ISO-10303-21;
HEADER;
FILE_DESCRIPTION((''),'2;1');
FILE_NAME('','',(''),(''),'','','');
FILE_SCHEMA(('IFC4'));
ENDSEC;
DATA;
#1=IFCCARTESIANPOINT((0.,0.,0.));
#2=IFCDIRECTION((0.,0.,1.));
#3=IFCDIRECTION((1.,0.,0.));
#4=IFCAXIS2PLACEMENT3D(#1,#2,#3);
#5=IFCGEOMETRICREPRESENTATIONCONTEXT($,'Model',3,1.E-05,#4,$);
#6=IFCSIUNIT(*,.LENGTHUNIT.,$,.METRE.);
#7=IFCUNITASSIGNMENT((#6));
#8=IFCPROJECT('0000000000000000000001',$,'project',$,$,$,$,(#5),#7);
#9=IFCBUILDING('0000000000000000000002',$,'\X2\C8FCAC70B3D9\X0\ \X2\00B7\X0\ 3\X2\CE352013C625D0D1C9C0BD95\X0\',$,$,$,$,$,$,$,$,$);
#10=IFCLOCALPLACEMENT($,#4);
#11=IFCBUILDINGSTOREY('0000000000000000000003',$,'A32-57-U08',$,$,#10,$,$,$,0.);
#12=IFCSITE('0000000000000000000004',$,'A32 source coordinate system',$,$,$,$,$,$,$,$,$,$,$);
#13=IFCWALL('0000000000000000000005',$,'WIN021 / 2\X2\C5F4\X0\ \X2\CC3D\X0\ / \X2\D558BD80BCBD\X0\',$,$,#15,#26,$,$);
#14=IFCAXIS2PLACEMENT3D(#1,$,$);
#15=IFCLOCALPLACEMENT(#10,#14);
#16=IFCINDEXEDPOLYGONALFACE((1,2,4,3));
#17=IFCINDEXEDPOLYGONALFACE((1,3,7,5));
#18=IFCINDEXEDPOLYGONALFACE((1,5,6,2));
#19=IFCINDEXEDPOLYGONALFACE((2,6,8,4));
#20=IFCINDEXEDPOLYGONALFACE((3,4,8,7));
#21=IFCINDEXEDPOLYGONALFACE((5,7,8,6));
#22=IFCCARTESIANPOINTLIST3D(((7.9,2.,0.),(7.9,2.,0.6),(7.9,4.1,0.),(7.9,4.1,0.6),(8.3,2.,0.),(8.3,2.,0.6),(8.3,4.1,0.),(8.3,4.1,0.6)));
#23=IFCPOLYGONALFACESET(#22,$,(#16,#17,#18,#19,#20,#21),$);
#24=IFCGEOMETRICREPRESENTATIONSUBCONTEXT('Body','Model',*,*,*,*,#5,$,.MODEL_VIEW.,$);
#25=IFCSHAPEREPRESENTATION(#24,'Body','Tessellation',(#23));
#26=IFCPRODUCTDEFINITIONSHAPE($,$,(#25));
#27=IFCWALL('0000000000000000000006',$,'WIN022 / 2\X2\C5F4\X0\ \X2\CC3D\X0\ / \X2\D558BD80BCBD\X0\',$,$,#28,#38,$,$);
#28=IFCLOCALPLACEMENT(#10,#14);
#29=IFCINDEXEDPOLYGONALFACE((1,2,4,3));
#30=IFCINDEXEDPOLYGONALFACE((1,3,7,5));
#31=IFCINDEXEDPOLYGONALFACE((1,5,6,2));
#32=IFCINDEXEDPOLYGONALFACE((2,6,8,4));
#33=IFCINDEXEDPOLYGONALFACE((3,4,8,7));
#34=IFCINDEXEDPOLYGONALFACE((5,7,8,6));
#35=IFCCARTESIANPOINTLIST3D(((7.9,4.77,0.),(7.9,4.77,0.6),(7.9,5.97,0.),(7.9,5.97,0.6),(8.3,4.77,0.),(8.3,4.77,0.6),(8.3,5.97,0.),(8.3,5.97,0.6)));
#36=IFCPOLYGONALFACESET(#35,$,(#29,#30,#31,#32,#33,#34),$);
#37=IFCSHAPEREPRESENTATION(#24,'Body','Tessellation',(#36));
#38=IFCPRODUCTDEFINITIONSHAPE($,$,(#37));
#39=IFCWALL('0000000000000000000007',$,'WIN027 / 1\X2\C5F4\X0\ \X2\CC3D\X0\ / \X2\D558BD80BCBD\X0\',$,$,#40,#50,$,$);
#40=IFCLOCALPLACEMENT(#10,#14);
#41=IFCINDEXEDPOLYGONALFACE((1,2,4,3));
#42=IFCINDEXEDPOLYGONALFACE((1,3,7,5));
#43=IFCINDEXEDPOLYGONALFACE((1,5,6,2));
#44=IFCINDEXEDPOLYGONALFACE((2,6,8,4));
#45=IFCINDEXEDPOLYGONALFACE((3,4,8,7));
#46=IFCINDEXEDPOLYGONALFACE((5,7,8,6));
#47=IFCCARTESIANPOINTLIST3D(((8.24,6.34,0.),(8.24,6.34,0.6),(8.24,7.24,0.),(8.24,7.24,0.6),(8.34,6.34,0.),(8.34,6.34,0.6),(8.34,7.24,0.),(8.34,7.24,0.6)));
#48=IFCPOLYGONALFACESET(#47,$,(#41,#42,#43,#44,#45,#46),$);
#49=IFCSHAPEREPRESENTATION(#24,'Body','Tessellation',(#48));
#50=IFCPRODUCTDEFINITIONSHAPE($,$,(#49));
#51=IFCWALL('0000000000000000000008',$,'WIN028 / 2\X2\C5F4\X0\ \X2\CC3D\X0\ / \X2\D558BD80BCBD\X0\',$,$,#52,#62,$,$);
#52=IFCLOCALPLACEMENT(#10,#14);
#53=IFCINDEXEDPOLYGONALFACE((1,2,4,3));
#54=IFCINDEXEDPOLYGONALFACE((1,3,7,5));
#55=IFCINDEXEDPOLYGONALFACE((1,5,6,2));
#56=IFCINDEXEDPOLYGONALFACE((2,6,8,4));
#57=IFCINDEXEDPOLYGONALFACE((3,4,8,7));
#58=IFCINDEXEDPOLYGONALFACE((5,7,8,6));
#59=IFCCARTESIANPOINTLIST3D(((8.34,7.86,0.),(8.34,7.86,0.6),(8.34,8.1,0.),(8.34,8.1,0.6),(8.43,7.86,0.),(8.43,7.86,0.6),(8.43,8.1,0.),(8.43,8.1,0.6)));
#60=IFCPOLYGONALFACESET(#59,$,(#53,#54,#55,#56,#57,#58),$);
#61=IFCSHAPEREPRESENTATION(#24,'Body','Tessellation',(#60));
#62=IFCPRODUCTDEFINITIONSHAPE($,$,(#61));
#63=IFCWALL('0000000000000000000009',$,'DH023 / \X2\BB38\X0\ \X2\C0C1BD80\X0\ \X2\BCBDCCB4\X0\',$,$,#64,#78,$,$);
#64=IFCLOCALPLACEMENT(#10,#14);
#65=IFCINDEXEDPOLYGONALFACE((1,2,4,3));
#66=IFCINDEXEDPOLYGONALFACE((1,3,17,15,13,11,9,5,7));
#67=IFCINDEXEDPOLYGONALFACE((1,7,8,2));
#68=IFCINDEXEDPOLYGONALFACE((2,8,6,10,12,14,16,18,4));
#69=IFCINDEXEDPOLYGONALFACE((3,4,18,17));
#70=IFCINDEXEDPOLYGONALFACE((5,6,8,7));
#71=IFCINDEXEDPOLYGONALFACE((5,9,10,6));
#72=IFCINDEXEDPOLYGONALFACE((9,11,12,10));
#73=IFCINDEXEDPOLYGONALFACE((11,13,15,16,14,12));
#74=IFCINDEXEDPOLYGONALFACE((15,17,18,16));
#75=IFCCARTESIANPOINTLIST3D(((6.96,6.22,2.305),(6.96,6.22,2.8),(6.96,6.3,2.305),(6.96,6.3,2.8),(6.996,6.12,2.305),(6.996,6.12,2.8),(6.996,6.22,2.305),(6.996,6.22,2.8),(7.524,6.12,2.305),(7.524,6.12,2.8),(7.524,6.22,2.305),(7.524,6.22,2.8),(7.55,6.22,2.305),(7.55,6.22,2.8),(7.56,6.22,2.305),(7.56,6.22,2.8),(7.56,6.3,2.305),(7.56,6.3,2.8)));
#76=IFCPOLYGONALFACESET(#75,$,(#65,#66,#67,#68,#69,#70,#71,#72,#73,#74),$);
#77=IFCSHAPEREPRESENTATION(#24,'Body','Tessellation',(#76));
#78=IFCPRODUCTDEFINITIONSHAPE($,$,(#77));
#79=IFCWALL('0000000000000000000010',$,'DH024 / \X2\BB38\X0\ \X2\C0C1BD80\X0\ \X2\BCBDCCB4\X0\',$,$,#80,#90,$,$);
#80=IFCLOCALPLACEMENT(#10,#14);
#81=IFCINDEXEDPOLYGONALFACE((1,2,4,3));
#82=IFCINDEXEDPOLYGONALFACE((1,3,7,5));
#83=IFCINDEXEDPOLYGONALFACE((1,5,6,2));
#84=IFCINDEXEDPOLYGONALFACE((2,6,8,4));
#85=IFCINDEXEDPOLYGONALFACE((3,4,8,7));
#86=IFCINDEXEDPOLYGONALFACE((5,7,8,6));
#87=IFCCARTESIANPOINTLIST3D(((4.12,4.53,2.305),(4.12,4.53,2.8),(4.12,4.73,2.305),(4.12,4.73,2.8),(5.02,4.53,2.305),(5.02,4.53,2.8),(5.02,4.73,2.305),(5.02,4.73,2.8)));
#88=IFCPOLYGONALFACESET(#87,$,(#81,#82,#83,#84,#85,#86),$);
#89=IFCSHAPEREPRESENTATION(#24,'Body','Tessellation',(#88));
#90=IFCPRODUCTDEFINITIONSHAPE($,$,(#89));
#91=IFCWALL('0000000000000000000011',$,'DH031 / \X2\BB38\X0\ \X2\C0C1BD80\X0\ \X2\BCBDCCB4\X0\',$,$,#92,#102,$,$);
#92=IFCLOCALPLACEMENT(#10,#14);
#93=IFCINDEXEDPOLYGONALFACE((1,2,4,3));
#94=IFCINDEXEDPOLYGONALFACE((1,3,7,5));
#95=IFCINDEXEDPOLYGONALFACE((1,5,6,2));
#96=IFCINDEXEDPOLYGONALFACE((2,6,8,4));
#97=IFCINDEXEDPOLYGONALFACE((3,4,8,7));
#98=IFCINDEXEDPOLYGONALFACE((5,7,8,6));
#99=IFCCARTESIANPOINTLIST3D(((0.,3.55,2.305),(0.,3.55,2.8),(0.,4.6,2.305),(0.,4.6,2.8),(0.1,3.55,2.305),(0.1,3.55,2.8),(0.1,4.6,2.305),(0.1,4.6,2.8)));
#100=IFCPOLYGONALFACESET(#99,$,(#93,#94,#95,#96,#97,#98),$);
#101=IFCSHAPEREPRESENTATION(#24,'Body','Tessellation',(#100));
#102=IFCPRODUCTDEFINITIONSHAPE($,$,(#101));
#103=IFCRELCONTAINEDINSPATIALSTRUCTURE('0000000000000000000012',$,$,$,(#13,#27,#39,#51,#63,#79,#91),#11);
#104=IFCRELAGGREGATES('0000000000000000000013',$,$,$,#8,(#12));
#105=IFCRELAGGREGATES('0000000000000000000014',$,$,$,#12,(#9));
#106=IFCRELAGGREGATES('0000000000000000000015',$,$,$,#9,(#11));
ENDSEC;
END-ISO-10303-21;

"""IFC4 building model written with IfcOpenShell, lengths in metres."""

from ifc_helpers import new_model, si_unit, frame, origin, origin_with_axes, place, context, subcontext, project, spatial, polyline, outline, extrude, element, save


model = new_model("IFC4")

# Units and contexts
model_context = context("Model", 3, precision=1e-05, world=origin_with_axes())
body_context = subcontext(model_context, "Body", "Model", "MODEL_VIEW")
ifc_project = project(units=[si_unit("LENGTHUNIT", "METRE")], contexts=[model_context])

# Site, building, storey
site = spatial("IfcSite", under=ifc_project, Name="A32 source coordinate system")
building = spatial("IfcBuilding", under=site, Name="주거동 · 3층–옥탑지붕")
storey_placement = place(None, origin_with_axes())
storey = spatial("IfcBuildingStorey", under=building, at=storey_placement, Name="A32-57-U08", Elevation=0.0)

# Walls
wall_1_placement = place(storey_placement, origin_with_axes())
element("IfcWall", 1, at=wall_1_placement, inside=storey, Name="WIN021 / 2열 창 / 하부벽", context=body_context, shape_type="SweptSolid", body=[
    extrude(outline(polyline([(7.9, 2.0), (7.9, 4.1), (8.3, 4.1), (8.3, 2.0), (7.9, 2.0)])), origin(), (0.0, 0.0, 1.0), 0.6),
])
wall_2_placement = place(storey_placement, origin_with_axes())
element("IfcWall", 2, at=wall_2_placement, inside=storey, Name="WIN022 / 2열 창 / 하부벽", context=body_context, shape_type="SweptSolid", body=[
    extrude(outline(polyline([(7.9, 4.77), (7.9, 5.97), (8.3, 5.97), (8.3, 4.77), (7.9, 4.77)])), origin(), (0.0, 0.0, 1.0), 0.6),
])
wall_3_placement = place(storey_placement, origin_with_axes())
element("IfcWall", 3, at=wall_3_placement, inside=storey, Name="WIN027 / 1열 창 / 하부벽", context=body_context, shape_type="SweptSolid", body=[
    extrude(outline(polyline([(8.24, 6.34), (8.24, 7.24), (8.34, 7.24), (8.34, 6.34), (8.24, 6.34)])), origin(), (0.0, 0.0, 1.0), 0.6),
])
wall_4_placement = place(storey_placement, origin_with_axes())
element("IfcWall", 4, at=wall_4_placement, inside=storey, Name="WIN028 / 2열 창 / 하부벽", context=body_context, shape_type="SweptSolid", body=[
    extrude(outline(polyline([(8.34, 7.86), (8.34, 8.1), (8.43, 8.1), (8.43, 7.86), (8.34, 7.86)])), origin(), (0.0, 0.0, 1.0), 0.6),
])
wall_5_placement = place(storey_placement, origin_with_axes())
element("IfcWall", 5, at=wall_5_placement, inside=storey, Name="DH023 / 문 상부 벽체", context=body_context, shape_type="SweptSolid", body=[
    extrude(outline(polyline([(6.96, 6.3), (7.56, 6.3), (7.56, 6.22), (7.55, 6.22), (7.524, 6.22), (7.524, 6.12), (6.996, 6.12), (6.996, 6.22), (6.96, 6.22), (6.96, 6.3)])), frame((0.0, 0.0, 2.305)), (0.0, 0.0, 1.0), 0.495),
])
wall_6_placement = place(storey_placement, origin_with_axes())
element("IfcWall", 6, at=wall_6_placement, inside=storey, Name="DH024 / 문 상부 벽체", context=body_context, shape_type="SweptSolid", body=[
    extrude(outline(polyline([(4.12, 4.73), (5.02, 4.73), (5.02, 4.53), (4.12, 4.53), (4.12, 4.73)])), frame((0.0, 0.0, 2.305)), (0.0, 0.0, 1.0), 0.495),
])
wall_7_placement = place(storey_placement, origin_with_axes())
element("IfcWall", 7, at=wall_7_placement, inside=storey, Name="DH031 / 문 상부 벽체", context=body_context, shape_type="SweptSolid", body=[
    extrude(outline(polyline([(0.0, 4.6), (0.1, 4.6), (0.1, 3.55), (0.0, 3.55), (0.0, 4.6)])), frame((0.0, 0.0, 2.305)), (0.0, 0.0, 1.0), 0.495),
])

save(model, "model.ifc")
